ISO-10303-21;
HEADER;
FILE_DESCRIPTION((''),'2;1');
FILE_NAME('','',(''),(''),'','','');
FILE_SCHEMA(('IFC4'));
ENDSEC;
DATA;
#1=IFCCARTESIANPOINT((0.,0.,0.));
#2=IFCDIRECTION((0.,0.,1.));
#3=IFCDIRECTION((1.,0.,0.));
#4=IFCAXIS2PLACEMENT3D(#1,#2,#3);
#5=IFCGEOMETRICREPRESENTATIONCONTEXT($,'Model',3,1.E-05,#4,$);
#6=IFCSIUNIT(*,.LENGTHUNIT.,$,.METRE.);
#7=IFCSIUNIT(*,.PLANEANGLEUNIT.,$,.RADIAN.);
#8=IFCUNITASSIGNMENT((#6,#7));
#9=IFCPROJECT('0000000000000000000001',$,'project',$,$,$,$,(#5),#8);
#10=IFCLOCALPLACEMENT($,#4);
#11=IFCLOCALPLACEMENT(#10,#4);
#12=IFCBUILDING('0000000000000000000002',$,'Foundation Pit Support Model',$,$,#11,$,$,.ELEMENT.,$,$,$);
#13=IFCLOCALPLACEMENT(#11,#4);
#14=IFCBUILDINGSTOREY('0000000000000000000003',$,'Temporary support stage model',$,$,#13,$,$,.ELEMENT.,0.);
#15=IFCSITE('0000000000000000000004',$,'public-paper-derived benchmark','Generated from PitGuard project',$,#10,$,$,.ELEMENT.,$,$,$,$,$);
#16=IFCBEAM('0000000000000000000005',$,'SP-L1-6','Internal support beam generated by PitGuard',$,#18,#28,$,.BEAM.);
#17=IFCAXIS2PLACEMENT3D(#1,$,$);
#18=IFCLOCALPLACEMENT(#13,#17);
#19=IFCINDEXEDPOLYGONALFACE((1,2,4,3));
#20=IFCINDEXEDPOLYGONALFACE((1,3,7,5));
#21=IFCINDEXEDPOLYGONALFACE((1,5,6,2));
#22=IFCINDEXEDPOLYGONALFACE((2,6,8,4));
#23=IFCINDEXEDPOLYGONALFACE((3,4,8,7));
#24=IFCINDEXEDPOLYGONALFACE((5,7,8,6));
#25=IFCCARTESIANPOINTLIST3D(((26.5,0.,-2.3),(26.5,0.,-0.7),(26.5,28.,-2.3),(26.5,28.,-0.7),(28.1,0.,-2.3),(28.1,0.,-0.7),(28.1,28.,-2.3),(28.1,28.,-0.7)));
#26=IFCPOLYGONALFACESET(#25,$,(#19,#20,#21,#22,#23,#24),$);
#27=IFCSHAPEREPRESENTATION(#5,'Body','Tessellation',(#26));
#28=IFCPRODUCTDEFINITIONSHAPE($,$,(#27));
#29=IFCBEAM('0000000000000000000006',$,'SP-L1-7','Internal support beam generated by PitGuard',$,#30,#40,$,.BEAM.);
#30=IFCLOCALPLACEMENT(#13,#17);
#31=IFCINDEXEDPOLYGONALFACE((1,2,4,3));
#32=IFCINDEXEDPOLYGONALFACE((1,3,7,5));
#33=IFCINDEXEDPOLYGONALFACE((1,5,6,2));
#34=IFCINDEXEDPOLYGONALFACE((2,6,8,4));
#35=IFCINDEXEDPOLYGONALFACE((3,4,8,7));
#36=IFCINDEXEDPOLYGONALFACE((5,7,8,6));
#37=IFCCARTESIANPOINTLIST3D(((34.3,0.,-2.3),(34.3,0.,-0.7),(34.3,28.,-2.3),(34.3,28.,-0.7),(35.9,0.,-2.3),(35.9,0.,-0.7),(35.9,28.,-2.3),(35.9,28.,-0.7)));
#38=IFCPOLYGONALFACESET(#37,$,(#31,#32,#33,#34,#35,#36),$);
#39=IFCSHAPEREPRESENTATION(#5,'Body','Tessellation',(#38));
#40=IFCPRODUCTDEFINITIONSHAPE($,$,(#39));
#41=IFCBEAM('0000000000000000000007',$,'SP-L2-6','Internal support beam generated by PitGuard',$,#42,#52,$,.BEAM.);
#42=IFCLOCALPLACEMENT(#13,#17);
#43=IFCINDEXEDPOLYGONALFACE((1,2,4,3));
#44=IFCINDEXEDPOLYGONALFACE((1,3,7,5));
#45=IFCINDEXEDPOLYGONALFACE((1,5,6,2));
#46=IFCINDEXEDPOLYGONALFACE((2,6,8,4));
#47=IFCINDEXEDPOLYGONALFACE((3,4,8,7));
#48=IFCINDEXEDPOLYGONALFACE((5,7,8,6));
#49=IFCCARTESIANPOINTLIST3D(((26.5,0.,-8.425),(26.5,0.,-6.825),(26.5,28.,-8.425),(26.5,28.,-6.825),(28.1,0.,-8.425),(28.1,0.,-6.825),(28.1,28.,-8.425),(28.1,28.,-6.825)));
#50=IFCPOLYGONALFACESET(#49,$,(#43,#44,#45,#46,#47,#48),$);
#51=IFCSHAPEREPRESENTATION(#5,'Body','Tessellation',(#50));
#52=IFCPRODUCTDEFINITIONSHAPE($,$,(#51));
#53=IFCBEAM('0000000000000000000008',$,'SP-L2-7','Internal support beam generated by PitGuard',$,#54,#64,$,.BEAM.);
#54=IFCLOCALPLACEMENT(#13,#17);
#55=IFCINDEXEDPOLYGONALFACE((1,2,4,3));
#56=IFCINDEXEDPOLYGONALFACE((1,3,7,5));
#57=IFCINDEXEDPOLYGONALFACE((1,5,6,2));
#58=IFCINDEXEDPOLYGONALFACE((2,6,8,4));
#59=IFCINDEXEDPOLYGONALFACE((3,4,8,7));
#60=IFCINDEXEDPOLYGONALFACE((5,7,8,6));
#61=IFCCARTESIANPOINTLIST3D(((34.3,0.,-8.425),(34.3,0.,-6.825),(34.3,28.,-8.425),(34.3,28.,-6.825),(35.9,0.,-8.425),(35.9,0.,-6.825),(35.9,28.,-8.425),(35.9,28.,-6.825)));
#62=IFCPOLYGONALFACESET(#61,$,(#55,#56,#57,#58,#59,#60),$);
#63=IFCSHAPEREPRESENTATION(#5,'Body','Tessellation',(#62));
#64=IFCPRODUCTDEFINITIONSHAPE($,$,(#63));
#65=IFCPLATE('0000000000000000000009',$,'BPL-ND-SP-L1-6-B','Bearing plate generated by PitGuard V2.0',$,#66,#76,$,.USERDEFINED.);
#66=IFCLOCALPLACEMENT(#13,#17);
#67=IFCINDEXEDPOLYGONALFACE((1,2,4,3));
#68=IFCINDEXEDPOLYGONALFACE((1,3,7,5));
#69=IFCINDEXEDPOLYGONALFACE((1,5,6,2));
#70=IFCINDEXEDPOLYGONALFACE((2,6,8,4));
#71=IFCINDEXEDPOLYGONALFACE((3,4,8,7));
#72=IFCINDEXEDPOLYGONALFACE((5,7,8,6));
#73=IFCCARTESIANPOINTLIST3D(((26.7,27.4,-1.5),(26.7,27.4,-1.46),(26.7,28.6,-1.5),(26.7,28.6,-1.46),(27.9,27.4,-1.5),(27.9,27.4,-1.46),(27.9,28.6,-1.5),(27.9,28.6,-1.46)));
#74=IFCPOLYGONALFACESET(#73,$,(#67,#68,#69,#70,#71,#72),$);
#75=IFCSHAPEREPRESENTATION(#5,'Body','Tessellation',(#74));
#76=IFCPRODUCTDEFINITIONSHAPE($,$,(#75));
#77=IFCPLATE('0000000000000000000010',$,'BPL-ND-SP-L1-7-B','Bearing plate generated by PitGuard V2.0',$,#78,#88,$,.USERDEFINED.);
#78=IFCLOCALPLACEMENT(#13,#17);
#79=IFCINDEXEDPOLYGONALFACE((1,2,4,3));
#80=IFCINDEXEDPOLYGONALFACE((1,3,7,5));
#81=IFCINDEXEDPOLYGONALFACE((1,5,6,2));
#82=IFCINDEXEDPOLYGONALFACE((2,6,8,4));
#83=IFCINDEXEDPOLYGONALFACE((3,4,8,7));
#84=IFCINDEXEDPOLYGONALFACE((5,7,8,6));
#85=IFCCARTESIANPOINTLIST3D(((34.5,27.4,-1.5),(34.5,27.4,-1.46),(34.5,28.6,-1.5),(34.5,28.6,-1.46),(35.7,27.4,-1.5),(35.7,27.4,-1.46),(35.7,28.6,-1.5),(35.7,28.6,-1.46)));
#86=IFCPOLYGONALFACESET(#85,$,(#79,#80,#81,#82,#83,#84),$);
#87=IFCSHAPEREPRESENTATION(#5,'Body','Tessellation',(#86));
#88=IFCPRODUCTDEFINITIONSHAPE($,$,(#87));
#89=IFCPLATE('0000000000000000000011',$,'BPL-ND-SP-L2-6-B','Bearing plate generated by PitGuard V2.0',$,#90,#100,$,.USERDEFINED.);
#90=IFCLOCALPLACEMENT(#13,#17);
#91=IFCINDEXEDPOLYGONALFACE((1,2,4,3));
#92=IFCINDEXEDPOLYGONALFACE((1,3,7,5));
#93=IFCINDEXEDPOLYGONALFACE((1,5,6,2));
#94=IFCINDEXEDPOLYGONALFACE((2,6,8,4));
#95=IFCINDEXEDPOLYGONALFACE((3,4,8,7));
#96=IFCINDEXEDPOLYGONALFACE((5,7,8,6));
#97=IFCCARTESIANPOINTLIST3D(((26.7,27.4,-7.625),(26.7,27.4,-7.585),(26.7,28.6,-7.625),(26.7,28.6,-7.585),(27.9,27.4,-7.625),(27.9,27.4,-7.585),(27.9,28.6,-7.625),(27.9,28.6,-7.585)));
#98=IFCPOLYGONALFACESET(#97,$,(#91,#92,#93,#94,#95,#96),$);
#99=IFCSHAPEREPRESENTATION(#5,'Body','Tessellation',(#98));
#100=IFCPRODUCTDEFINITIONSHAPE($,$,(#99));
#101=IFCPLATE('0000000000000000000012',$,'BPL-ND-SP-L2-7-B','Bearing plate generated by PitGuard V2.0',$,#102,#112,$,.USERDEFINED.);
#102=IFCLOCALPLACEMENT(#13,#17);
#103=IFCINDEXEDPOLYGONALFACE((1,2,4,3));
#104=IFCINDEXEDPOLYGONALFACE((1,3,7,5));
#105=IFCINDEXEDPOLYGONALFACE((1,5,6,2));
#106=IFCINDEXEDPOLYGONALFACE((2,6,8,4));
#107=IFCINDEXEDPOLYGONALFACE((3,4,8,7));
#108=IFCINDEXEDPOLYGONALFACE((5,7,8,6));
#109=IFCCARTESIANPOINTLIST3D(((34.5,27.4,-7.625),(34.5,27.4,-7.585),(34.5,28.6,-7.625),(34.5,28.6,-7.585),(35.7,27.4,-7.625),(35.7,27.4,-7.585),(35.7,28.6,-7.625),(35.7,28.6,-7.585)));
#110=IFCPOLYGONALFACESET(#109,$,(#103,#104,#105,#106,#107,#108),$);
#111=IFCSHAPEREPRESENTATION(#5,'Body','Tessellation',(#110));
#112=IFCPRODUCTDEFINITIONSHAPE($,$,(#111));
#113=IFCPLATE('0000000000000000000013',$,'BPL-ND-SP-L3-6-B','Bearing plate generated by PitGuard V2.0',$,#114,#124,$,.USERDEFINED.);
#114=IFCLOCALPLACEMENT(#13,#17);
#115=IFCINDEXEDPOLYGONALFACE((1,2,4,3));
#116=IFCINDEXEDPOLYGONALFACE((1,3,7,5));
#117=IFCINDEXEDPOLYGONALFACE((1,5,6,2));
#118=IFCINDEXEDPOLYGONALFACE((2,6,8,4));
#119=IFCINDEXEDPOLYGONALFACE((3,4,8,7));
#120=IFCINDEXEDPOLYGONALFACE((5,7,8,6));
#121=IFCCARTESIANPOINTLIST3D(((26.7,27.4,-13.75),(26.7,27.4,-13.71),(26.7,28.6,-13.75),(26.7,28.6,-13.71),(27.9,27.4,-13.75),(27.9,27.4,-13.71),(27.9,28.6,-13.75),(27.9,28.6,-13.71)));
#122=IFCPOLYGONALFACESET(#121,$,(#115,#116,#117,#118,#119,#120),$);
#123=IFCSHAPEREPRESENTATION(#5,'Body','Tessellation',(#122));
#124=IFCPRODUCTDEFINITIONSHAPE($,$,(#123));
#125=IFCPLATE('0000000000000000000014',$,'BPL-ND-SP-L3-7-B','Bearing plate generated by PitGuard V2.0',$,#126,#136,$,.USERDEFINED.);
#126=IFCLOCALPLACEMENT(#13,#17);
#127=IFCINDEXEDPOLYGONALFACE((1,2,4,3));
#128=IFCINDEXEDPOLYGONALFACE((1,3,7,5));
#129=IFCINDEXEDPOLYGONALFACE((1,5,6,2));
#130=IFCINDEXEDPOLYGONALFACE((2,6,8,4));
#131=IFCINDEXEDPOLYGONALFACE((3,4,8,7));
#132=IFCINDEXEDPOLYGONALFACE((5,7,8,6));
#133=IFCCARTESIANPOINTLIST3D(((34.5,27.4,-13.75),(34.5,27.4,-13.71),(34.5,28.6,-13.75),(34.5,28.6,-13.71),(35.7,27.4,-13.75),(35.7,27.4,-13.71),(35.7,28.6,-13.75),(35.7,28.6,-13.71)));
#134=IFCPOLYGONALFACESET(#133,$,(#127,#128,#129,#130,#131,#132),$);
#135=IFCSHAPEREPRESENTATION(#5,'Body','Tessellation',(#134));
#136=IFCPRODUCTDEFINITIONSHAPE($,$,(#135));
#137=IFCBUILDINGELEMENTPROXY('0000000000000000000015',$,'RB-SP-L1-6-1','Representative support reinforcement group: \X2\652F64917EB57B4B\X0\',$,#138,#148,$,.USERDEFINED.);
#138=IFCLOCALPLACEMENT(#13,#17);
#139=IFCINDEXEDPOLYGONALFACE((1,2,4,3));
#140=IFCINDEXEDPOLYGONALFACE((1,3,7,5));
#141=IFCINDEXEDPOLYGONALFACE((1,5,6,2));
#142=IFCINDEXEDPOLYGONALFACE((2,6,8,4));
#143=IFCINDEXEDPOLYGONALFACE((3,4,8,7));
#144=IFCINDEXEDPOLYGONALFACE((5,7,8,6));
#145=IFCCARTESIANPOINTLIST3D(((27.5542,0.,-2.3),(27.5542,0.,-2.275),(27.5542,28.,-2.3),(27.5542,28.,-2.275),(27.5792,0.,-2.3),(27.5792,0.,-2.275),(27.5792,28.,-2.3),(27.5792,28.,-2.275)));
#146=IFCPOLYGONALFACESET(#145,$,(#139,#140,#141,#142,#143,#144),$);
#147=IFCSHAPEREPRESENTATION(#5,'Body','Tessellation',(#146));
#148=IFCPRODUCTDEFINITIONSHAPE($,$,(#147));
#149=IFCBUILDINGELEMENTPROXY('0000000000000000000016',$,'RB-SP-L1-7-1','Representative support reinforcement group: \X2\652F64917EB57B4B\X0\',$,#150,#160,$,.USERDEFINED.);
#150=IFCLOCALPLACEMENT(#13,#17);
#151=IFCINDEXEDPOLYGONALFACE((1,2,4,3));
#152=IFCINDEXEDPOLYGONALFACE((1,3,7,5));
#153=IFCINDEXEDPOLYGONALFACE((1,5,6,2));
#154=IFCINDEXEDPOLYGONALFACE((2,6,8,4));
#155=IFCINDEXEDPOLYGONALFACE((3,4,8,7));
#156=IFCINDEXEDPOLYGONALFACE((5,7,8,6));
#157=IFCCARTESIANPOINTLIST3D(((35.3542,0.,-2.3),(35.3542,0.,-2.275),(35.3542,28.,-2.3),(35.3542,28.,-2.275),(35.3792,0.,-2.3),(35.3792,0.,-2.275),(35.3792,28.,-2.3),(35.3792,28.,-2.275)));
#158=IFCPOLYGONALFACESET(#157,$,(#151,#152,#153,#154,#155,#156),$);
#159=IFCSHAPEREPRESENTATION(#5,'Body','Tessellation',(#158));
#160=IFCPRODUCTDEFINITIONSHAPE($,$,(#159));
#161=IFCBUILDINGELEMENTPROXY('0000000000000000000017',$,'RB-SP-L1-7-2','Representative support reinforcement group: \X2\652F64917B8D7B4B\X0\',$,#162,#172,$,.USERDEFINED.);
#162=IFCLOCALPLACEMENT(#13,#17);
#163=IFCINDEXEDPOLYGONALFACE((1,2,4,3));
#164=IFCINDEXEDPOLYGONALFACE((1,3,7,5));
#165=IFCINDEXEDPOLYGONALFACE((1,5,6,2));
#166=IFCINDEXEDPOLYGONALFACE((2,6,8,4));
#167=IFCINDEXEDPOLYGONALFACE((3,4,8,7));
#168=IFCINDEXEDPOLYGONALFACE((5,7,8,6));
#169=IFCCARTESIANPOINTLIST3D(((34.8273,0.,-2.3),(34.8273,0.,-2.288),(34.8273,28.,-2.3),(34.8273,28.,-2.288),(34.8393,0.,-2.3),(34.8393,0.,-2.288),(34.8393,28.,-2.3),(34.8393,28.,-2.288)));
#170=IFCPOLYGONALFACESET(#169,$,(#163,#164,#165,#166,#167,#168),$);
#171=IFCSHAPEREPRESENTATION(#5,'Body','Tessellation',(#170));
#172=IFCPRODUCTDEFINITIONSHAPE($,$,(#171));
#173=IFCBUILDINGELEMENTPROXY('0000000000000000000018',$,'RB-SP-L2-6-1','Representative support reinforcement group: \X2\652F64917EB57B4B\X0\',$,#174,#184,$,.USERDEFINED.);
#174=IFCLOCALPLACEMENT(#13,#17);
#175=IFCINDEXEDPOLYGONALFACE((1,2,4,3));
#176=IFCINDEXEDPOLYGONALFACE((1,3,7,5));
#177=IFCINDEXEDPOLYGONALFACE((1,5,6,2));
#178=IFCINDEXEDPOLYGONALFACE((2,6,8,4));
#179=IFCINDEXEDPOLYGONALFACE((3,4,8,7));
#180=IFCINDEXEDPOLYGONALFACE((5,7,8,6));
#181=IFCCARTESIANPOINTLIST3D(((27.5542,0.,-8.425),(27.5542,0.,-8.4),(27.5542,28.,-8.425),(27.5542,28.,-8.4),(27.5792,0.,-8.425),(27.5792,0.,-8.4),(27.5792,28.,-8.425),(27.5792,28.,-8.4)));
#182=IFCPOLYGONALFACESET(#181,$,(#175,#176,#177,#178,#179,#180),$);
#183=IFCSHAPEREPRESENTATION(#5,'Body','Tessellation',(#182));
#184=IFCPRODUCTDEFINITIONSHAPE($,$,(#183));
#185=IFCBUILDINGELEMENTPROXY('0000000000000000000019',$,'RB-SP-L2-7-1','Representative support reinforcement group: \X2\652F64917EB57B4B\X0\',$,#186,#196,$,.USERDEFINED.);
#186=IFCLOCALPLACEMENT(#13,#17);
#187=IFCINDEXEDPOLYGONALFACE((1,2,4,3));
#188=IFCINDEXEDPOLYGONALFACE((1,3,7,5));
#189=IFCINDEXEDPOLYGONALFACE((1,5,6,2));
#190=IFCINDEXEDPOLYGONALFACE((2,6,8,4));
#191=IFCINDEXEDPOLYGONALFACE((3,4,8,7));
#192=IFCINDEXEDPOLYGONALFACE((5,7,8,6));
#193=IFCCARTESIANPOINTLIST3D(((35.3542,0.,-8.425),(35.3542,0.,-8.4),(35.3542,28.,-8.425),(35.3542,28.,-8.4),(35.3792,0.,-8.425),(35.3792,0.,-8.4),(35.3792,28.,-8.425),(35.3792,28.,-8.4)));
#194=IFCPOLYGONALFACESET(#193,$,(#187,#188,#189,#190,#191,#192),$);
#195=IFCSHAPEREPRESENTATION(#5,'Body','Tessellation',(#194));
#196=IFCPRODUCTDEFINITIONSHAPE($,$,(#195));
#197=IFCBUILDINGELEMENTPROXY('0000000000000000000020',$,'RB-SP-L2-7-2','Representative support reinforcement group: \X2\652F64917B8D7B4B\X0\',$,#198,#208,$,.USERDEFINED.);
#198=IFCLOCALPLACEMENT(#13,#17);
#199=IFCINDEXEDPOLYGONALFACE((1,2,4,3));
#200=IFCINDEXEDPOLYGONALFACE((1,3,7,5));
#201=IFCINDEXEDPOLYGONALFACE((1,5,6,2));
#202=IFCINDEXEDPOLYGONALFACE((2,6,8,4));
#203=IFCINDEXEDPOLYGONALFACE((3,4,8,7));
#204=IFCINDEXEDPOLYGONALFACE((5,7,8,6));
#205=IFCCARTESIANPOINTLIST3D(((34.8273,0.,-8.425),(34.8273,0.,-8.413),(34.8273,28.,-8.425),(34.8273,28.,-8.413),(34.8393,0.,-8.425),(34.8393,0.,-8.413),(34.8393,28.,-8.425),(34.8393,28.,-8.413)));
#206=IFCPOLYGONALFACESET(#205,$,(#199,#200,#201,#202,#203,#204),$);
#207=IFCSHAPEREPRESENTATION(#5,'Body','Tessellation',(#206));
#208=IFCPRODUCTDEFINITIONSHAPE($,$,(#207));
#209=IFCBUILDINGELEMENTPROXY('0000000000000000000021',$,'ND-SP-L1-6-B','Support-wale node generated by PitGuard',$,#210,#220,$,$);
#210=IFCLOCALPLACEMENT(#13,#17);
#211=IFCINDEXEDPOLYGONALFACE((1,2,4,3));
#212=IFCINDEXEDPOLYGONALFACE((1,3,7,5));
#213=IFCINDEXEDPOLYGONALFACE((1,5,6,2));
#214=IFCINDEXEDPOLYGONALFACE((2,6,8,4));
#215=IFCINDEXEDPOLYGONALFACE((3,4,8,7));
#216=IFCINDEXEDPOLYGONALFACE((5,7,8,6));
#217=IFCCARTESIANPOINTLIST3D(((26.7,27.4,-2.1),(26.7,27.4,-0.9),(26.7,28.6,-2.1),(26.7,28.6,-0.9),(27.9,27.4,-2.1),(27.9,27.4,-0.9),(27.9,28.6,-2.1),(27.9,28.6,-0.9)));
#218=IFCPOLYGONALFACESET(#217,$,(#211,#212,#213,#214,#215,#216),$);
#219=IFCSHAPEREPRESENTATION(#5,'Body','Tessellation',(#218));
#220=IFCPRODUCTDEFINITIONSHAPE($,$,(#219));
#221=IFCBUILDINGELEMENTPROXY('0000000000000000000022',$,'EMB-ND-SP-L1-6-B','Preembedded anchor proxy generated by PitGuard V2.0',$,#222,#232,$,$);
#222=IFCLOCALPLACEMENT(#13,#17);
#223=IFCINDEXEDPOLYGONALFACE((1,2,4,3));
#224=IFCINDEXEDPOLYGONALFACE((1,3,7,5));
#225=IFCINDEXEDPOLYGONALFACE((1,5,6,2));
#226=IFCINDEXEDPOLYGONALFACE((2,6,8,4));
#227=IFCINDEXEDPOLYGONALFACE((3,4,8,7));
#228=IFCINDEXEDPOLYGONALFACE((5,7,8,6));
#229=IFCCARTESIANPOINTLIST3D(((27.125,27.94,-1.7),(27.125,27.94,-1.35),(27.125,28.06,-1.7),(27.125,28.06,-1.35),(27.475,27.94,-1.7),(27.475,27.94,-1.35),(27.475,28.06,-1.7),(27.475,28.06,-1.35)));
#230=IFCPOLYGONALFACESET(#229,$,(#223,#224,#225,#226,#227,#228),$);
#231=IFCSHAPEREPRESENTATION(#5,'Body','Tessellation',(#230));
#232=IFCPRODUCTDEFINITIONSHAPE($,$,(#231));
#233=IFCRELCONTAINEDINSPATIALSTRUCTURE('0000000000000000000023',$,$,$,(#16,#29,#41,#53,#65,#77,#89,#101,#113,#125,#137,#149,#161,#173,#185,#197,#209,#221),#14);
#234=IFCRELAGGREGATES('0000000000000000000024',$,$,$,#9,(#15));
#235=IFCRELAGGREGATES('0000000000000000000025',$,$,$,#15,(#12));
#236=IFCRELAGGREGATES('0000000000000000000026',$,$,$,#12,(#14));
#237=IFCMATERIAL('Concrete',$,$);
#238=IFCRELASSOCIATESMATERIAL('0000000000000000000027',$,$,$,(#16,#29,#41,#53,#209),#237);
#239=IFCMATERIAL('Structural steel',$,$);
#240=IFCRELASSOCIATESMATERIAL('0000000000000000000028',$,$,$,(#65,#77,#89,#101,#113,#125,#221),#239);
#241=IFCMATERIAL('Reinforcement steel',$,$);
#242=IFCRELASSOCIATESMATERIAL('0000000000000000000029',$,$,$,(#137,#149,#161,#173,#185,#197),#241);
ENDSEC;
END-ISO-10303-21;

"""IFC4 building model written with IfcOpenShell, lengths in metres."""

from ifc_helpers import new_model, si_unit, frame, origin_with_axes, origin_2d, place, context, project, spatial, rectangle, extrude, material, element, save


model = new_model("IFC4")

# Units and contexts
model_context = context("Model", 3, precision=1e-05, world=origin_with_axes())
ifc_project = project(units=[si_unit("LENGTHUNIT", "METRE"), si_unit("PLANEANGLEUNIT", "RADIAN")], contexts=[model_context])

# Site, building, storey
site_placement = place(None, origin_with_axes())
site = spatial("IfcSite", under=ifc_project, at=site_placement, Name="public-paper-derived benchmark", Description="Generated from PitGuard project", CompositionType="ELEMENT")
building_placement = place(site_placement, origin_with_axes())
building = spatial("IfcBuilding", under=site, at=building_placement, Name="Foundation Pit Support Model", CompositionType="ELEMENT")
storey_placement = place(building_placement, origin_with_axes())
storey = spatial("IfcBuildingStorey", under=building, at=storey_placement, Name="Temporary support stage model", CompositionType="ELEMENT", Elevation=0.0)

# Beams
ifc_material_1 = material(Name="Concrete")
for number, where, z_axis, x_axis, name in (
    (1, (27.3, 14.0, -2.3), (0.0, 0.0, 1.0), (0.0, 1.0, 0.0), "SP-L1-6"),
    (2, (35.1, 14.0, -2.3), (0.0, 0.0, 1.0), (0.0, 1.0, 0.0), "SP-L1-7"),
    (3, (27.3, 14.0, -8.425), (0.0, 0.0, 1.0), (0.0, 1.0, 0.0), "SP-L2-6"),
    (4, (35.1, 14.0, -8.425), (0.0, 0.0, 1.0), (0.0, 1.0, 0.0), "SP-L2-7"),
):
    element("IfcBeam", number, at=place(storey_placement, frame(where, z_axis=z_axis, x_axis=x_axis)), inside=storey, material=ifc_material_1, Name=name, Description="Internal support beam generated by PitGuard", PredefinedType="BEAM", context=model_context, shape_type="SweptSolid", body=[
        extrude(rectangle(XDim=28.0, YDim=1.6, at=origin_2d()), origin_with_axes(), (0.0, 0.0, 1.0), 1.6),
    ])

# Plates
ifc_material_2 = material(Name="Structural steel")
for number, where, z_axis, x_axis, name in (
    (5, (27.3, 28.0, -1.5), (0.0, 0.0, 1.0), (1.0, 0.0, 0.0), "BPL-ND-SP-L1-6-B"),
    (6, (35.1, 28.0, -1.5), (0.0, 0.0, 1.0), (1.0, 0.0, 0.0), "BPL-ND-SP-L1-7-B"),
    (7, (27.3, 28.0, -7.625), (0.0, 0.0, 1.0), (1.0, 0.0, 0.0), "BPL-ND-SP-L2-6-B"),
    (8, (35.1, 28.0, -7.625), (0.0, 0.0, 1.0), (1.0, 0.0, 0.0), "BPL-ND-SP-L2-7-B"),
    (9, (27.3, 28.0, -13.75), (0.0, 0.0, 1.0), (1.0, 0.0, 0.0), "BPL-ND-SP-L3-6-B"),
    (10, (35.1, 28.0, -13.75), (0.0, 0.0, 1.0), (1.0, 0.0, 0.0), "BPL-ND-SP-L3-7-B"),
):
    element("IfcPlate", number, at=place(storey_placement, frame(where, z_axis=z_axis, x_axis=x_axis)), inside=storey, material=ifc_material_2, Name=name, Description="Bearing plate generated by PitGuard V2.0", PredefinedType="USERDEFINED", context=model_context, shape_type="SweptSolid", body=[
        extrude(rectangle(XDim=1.2, YDim=1.2, at=origin_2d()), origin_with_axes(), (0.0, 0.0, 1.0), 0.04),
    ])

# Building element proxies
ifc_material_3 = material(Name="Reinforcement steel")
for number, where, z_axis, x_axis, name in (
    (11, (27.5667, 14.0, -2.3), (0.0, 0.0, 1.0), (0.0, 1.0, 0.0), "RB-SP-L1-6-1"),
    (12, (35.3667, 14.0, -2.3), (0.0, 0.0, 1.0), (0.0, 1.0, 0.0), "RB-SP-L1-7-1"),
):
    element("IfcBuildingElementProxy", number, at=place(storey_placement, frame(where, z_axis=z_axis, x_axis=x_axis)), inside=storey, material=ifc_material_3, Name=name, Description="Representative support reinforcement group: 支撑纵筋", PredefinedType="USERDEFINED", context=model_context, shape_type="SweptSolid", body=[
        extrude(rectangle(XDim=28.0, YDim=0.025, at=origin_2d()), origin_with_axes(), (0.0, 0.0, 1.0), 0.025),
    ])
proxy_1_placement = place(storey_placement, frame((34.8333, 14.0, -2.3), z_axis=(0.0, 0.0, 1.0), x_axis=(0.0, 1.0, 0.0)))
element("IfcBuildingElementProxy", 13, at=proxy_1_placement, inside=storey, material=ifc_material_3, Name="RB-SP-L1-7-2", Description="Representative support reinforcement group: 支撑箍筋", PredefinedType="USERDEFINED", context=model_context, shape_type="SweptSolid", body=[
    extrude(rectangle(XDim=28.0, YDim=0.012, at=origin_2d()), origin_with_axes(), (0.0, 0.0, 1.0), 0.012),
])
for number, where, z_axis, x_axis, name in (
    (14, (27.5667, 14.0, -8.425), (0.0, 0.0, 1.0), (0.0, 1.0, 0.0), "RB-SP-L2-6-1"),
    (15, (35.3667, 14.0, -8.425), (0.0, 0.0, 1.0), (0.0, 1.0, 0.0), "RB-SP-L2-7-1"),
):
    element("IfcBuildingElementProxy", number, at=place(storey_placement, frame(where, z_axis=z_axis, x_axis=x_axis)), inside=storey, material=ifc_material_3, Name=name, Description="Representative support reinforcement group: 支撑纵筋", PredefinedType="USERDEFINED", context=model_context, shape_type="SweptSolid", body=[
        extrude(rectangle(XDim=28.0, YDim=0.025, at=origin_2d()), origin_with_axes(), (0.0, 0.0, 1.0), 0.025),
    ])
proxy_2_placement = place(storey_placement, frame((34.8333, 14.0, -8.425), z_axis=(0.0, 0.0, 1.0), x_axis=(0.0, 1.0, 0.0)))
element("IfcBuildingElementProxy", 16, at=proxy_2_placement, inside=storey, material=ifc_material_3, Name="RB-SP-L2-7-2", Description="Representative support reinforcement group: 支撑箍筋", PredefinedType="USERDEFINED", context=model_context, shape_type="SweptSolid", body=[
    extrude(rectangle(XDim=28.0, YDim=0.012, at=origin_2d()), origin_with_axes(), (0.0, 0.0, 1.0), 0.012),
])
proxy_3_placement = place(storey_placement, frame((27.3, 28.0, -2.1), z_axis=(0.0, 0.0, 1.0), x_axis=(1.0, 0.0, 0.0)))
element("IfcBuildingElementProxy", 17, at=proxy_3_placement, inside=storey, material=ifc_material_1, Name="ND-SP-L1-6-B", Description="Support-wale node generated by PitGuard", context=model_context, shape_type="SweptSolid", body=[
    extrude(rectangle(XDim=1.2, YDim=1.2, at=origin_2d()), origin_with_axes(), (0.0, 0.0, 1.0), 1.2),
])
proxy_4_placement = place(storey_placement, frame((27.3, 28.0, -1.7), z_axis=(0.0, 0.0, 1.0), x_axis=(1.0, 0.0, 0.0)))
element("IfcBuildingElementProxy", 18, at=proxy_4_placement, inside=storey, material=ifc_material_2, Name="EMB-ND-SP-L1-6-B", Description="Preembedded anchor proxy generated by PitGuard V2.0", context=model_context, shape_type="SweptSolid", body=[
    extrude(rectangle(XDim=0.35, YDim=0.12, at=origin_2d()), origin_with_axes(), (0.0, 0.0, 1.0), 0.35),
])

save(model, "model.ifc")
